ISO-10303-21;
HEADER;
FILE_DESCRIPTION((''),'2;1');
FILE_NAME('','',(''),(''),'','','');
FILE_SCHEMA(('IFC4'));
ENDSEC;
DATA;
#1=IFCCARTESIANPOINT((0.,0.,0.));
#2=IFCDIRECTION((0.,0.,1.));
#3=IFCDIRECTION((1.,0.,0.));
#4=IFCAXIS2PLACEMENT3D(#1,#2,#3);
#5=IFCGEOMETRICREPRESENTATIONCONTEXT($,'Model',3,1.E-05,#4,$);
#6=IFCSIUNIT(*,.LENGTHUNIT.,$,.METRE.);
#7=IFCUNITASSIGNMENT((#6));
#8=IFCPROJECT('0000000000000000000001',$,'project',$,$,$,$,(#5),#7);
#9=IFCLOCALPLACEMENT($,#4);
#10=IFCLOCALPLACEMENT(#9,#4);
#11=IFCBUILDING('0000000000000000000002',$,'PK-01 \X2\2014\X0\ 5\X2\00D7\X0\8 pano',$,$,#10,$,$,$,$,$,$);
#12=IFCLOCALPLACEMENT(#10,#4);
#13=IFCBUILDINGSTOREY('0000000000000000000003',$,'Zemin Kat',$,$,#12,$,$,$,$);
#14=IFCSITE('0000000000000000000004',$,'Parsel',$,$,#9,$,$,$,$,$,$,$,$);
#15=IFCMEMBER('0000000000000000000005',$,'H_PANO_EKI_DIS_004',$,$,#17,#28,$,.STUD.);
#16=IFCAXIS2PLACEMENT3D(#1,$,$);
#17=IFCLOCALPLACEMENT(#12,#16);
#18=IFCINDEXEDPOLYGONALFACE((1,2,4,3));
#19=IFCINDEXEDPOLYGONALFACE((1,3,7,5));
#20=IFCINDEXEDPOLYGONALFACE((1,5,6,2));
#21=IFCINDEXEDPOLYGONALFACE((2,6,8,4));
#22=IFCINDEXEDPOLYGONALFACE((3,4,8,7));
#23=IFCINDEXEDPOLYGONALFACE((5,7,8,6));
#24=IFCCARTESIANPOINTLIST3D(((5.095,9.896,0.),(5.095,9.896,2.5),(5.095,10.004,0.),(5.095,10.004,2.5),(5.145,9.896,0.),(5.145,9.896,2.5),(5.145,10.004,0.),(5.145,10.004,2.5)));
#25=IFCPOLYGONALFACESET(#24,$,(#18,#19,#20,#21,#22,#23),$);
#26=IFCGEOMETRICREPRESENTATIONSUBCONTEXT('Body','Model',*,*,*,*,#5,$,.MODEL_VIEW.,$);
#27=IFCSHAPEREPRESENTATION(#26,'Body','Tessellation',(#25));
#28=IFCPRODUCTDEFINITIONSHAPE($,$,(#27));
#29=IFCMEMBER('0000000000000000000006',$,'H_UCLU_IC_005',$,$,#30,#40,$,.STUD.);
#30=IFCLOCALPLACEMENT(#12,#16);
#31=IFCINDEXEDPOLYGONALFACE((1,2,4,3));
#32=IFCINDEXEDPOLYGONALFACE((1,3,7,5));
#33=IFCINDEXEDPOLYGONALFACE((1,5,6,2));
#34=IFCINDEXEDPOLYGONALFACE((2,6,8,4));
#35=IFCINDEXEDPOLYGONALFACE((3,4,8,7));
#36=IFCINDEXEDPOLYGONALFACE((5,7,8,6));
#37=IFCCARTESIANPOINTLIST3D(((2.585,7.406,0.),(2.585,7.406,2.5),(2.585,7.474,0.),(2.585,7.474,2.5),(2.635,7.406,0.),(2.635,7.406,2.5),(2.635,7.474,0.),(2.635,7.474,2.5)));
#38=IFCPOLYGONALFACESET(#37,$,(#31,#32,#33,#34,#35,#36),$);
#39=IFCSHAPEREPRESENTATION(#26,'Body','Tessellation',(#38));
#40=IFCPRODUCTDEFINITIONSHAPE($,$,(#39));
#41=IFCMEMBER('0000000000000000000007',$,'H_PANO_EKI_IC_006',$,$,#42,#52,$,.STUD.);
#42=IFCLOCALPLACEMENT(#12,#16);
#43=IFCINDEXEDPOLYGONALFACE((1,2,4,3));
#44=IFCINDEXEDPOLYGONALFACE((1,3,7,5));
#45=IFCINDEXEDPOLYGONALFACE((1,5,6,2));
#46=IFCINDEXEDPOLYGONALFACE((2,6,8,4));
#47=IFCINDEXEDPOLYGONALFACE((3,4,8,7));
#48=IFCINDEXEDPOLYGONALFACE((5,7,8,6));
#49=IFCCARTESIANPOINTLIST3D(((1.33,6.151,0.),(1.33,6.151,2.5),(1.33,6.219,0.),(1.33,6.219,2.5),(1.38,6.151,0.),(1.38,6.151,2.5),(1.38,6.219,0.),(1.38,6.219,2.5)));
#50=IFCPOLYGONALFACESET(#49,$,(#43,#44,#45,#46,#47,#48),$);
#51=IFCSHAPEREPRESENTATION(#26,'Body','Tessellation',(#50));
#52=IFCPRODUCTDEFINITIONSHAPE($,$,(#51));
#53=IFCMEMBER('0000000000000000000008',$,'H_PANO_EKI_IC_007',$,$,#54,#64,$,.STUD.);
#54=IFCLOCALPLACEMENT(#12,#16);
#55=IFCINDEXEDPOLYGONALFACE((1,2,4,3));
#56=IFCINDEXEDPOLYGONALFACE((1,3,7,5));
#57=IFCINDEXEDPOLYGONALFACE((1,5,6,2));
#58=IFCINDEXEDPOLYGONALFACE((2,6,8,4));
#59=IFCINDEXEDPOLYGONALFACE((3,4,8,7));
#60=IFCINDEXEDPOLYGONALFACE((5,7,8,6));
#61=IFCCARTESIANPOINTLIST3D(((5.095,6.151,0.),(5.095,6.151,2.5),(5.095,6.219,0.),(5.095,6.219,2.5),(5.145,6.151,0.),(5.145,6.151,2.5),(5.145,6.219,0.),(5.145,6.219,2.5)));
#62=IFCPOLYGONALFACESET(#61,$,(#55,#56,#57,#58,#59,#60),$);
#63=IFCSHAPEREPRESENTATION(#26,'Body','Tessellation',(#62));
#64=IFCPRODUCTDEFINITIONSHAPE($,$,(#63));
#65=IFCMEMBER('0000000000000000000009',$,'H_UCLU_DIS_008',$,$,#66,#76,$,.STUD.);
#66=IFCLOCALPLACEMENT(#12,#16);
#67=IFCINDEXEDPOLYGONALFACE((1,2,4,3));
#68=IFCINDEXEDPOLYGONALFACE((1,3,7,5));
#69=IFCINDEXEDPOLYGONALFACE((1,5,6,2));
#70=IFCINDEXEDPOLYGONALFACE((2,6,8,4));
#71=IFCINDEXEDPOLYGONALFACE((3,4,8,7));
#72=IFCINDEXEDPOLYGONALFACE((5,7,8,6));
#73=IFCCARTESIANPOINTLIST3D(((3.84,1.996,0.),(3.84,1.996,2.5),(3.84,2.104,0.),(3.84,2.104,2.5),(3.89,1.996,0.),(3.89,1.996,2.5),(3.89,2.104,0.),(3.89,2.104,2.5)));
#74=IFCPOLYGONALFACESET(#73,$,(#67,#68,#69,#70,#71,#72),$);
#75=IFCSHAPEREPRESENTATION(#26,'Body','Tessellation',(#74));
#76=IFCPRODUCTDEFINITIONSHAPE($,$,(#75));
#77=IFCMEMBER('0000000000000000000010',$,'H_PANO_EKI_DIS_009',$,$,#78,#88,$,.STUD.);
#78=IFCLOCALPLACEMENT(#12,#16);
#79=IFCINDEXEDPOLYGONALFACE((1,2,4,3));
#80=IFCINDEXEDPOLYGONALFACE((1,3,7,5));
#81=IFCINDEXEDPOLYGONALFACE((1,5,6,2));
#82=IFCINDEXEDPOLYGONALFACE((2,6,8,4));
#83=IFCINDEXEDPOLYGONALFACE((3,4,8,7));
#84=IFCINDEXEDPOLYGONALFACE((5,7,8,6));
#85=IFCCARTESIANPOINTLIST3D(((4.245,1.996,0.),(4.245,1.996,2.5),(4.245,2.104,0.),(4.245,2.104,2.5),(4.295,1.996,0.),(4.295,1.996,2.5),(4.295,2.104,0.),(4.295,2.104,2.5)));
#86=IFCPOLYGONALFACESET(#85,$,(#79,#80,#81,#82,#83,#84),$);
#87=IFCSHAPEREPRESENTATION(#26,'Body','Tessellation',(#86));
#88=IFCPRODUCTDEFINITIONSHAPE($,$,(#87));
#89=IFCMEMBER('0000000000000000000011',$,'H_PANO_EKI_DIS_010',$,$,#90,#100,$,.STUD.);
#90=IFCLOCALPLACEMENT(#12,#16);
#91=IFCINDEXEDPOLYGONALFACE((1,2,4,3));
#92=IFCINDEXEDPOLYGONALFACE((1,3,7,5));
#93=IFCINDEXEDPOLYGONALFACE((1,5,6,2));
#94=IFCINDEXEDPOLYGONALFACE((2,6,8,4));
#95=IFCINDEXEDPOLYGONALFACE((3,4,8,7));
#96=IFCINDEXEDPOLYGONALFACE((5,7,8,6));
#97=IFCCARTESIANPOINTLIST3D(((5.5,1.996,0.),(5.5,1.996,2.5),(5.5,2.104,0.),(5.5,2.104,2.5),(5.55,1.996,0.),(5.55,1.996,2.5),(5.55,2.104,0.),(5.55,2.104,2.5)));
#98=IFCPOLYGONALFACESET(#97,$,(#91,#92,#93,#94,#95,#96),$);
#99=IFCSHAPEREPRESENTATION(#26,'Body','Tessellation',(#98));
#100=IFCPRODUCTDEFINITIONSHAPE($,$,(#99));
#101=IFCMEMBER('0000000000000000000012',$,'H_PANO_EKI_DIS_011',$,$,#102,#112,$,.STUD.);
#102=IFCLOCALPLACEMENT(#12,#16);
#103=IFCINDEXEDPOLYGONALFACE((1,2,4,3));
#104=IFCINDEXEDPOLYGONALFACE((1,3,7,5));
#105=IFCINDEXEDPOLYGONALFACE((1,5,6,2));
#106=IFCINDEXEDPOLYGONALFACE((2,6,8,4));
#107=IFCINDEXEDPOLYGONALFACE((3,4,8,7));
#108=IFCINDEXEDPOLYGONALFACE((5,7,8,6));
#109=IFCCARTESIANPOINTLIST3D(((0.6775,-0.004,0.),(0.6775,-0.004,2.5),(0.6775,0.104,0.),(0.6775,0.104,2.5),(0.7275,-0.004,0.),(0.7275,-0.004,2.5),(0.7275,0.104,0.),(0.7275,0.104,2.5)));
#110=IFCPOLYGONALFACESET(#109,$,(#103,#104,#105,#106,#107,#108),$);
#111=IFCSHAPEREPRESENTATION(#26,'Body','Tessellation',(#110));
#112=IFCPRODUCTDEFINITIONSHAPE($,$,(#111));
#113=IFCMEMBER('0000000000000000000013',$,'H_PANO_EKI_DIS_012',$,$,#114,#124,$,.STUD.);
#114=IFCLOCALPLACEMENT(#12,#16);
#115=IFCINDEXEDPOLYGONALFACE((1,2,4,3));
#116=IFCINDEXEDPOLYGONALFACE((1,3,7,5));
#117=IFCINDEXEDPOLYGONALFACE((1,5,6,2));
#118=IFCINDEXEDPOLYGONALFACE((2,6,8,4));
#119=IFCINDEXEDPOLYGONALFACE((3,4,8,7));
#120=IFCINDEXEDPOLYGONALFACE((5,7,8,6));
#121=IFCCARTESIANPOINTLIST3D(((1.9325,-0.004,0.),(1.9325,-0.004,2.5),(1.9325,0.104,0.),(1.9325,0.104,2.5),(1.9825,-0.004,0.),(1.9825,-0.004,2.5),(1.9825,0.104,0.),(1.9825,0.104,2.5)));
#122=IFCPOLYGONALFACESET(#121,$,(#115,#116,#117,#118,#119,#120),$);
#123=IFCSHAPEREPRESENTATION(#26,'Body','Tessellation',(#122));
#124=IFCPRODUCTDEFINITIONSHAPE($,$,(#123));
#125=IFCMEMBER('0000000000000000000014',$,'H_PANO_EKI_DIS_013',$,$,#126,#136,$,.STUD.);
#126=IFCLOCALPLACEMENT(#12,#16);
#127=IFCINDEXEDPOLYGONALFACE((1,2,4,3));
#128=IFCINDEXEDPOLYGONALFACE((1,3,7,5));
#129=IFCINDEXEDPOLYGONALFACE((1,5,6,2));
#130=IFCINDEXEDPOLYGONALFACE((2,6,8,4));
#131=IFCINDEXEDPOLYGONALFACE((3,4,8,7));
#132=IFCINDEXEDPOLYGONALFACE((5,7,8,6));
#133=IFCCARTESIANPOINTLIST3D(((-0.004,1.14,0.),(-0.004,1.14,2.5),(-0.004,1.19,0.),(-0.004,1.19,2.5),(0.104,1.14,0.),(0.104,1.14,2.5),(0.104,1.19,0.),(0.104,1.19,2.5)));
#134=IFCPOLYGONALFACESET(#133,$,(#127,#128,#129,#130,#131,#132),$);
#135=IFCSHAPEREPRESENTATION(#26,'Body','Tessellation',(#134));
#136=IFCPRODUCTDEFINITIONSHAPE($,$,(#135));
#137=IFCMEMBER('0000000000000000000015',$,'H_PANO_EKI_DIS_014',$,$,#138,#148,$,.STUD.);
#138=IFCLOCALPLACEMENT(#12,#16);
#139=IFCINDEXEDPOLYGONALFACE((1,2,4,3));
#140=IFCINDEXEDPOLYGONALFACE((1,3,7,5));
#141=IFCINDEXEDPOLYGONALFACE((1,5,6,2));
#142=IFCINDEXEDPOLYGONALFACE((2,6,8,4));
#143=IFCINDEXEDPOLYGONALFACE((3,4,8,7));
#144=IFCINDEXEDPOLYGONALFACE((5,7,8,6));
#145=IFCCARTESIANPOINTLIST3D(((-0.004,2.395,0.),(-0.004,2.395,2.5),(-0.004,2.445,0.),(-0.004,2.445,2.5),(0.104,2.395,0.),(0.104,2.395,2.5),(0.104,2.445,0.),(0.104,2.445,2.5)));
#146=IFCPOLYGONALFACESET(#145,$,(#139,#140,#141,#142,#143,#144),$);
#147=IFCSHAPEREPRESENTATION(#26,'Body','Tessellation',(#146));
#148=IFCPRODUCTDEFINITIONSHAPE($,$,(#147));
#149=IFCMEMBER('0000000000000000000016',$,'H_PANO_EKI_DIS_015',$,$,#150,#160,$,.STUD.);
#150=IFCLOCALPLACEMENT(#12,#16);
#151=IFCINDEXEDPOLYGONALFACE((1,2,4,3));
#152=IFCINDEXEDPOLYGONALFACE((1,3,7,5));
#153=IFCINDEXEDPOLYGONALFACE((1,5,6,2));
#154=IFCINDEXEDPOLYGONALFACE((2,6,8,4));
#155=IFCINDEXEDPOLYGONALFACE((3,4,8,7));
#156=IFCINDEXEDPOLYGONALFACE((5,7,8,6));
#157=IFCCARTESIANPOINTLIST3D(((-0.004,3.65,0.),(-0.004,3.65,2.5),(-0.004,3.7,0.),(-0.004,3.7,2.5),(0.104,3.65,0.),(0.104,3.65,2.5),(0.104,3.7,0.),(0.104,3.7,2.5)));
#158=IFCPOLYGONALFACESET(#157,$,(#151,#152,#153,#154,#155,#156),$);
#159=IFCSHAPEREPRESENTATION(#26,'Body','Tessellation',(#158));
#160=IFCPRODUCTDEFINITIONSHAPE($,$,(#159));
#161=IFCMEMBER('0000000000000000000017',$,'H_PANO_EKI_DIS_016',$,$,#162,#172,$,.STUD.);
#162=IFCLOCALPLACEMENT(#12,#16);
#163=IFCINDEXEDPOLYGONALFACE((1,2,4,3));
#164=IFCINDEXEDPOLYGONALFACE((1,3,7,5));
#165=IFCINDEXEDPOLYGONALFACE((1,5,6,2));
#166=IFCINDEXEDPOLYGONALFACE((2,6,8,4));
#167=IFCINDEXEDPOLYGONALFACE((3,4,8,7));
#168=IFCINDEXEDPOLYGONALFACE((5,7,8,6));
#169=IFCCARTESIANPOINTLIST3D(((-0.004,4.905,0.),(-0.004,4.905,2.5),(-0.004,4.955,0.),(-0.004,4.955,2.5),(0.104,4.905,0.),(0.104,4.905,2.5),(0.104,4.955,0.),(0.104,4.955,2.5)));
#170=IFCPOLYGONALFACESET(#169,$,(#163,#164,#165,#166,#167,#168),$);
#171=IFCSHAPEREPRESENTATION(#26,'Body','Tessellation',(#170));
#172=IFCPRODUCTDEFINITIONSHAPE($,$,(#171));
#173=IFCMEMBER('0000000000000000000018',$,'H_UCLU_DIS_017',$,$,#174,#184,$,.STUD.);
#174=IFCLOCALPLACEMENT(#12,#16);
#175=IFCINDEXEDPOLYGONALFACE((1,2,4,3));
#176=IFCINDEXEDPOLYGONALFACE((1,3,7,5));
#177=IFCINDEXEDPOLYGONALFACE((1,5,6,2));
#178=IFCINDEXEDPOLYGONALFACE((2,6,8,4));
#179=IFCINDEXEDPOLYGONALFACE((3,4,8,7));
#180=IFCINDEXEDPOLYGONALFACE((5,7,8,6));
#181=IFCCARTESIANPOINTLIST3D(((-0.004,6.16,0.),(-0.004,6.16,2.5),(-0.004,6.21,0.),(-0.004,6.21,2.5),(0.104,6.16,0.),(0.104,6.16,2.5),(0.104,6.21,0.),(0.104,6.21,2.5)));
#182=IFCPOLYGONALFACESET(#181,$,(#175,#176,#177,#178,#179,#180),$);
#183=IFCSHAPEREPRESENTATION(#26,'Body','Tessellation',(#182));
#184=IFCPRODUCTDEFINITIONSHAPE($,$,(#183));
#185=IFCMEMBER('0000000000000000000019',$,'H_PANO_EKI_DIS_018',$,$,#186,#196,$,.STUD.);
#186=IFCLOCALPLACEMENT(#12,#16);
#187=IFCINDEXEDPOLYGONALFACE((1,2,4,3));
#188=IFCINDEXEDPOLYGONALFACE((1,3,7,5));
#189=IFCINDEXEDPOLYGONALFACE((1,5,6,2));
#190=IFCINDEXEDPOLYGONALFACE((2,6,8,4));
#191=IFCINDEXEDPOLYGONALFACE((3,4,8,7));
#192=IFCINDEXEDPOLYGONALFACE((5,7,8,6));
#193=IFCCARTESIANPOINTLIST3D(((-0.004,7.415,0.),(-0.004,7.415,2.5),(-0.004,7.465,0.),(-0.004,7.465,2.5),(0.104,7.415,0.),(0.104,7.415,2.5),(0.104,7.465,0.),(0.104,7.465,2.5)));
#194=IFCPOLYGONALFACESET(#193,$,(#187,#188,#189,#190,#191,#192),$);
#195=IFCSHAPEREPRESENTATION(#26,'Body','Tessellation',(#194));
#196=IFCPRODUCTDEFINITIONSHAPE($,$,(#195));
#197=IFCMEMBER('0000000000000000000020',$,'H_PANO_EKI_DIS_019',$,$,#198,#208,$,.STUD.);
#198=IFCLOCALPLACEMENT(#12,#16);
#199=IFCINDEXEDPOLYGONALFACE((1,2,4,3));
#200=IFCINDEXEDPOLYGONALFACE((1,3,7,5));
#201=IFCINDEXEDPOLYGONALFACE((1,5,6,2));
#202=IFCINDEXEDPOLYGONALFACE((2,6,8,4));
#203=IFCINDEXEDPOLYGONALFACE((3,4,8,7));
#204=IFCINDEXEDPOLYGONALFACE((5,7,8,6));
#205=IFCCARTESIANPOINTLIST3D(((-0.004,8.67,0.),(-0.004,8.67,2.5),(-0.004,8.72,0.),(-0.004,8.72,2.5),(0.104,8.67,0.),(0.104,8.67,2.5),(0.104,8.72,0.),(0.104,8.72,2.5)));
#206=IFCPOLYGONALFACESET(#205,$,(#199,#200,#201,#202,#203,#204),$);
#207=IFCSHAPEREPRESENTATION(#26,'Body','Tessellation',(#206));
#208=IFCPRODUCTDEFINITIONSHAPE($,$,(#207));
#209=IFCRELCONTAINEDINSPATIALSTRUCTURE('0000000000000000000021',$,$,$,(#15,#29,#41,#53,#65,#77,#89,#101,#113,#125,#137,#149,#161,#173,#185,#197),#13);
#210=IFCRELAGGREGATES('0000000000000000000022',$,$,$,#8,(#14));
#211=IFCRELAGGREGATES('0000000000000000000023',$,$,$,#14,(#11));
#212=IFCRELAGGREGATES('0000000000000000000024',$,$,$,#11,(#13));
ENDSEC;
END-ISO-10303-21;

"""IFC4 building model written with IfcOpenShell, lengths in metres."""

from ifc_helpers import new_model, si_unit, origin_with_axes, place, context, subcontext, project, spatial, line, indexed_curve, outline, extrude, element, save


model = new_model("IFC4")

# Units and contexts
model_context = context("Model", 3, precision=1e-05, world=origin_with_axes())
body_context = subcontext(model_context, "Body", "Model", "MODEL_VIEW")
ifc_project = project(units=[si_unit("LENGTHUNIT", "METRE")], contexts=[model_context])

# Site, building, storey
site_placement = place(None, origin_with_axes())
site = spatial("IfcSite", under=ifc_project, at=site_placement, Name="Parsel")
building_placement = place(site_placement, origin_with_axes())
building = spatial("IfcBuilding", under=site, at=building_placement, Name="PK-01 — 5×8 pano")
storey_placement = place(building_placement, origin_with_axes())
storey = spatial("IfcBuildingStorey", under=building, at=storey_placement, Name="Zemin Kat")

# Members
member_1_placement = place(storey_placement, origin_with_axes())
element("IfcMember", 1, at=member_1_placement, inside=storey, Name="H_PANO_EKI_DIS_004", PredefinedType="STUD", context=body_context, shape_type="SweptSolid", body=[
    extrude(outline(indexed_curve([(5.095, 9.896), (5.145, 9.896), (5.145, 10.004), (5.095, 10.004)], segments=[line(1, 2, 3, 4, 1)])), origin_with_axes(), (0.0, 0.0, 1.0), 2.5),
])
member_2_placement = place(storey_placement, origin_with_axes())
element("IfcMember", 2, at=member_2_placement, inside=storey, Name="H_UCLU_IC_005", PredefinedType="STUD", context=body_context, shape_type="SweptSolid", body=[
    extrude(outline(indexed_curve([(2.585, 7.406), (2.635, 7.406), (2.635, 7.474), (2.585, 7.474)], segments=[line(1, 2, 3, 4, 1)])), origin_with_axes(), (0.0, 0.0, 1.0), 2.5),
])
member_3_placement = place(storey_placement, origin_with_axes())
element("IfcMember", 3, at=member_3_placement, inside=storey, Name="H_PANO_EKI_IC_006", PredefinedType="STUD", context=body_context, shape_type="SweptSolid", body=[
    extrude(outline(indexed_curve([(1.33, 6.151), (1.38, 6.151), (1.38, 6.219), (1.33, 6.219)], segments=[line(1, 2, 3, 4, 1)])), origin_with_axes(), (0.0, 0.0, 1.0), 2.5),
])
member_4_placement = place(storey_placement, origin_with_axes())
element("IfcMember", 4, at=member_4_placement, inside=storey, Name="H_PANO_EKI_IC_007", PredefinedType="STUD", context=body_context, shape_type="SweptSolid", body=[
    extrude(outline(indexed_curve([(5.095, 6.151), (5.145, 6.151), (5.145, 6.219), (5.095, 6.219)], segments=[line(1, 2, 3, 4, 1)])), origin_with_axes(), (0.0, 0.0, 1.0), 2.5),
])
member_5_placement = place(storey_placement, origin_with_axes())
element("IfcMember", 5, at=member_5_placement, inside=storey, Name="H_UCLU_DIS_008", PredefinedType="STUD", context=body_context, shape_type="SweptSolid", body=[
    extrude(outline(indexed_curve([(3.84, 1.996), (3.89, 1.996), (3.89, 2.104), (3.84, 2.104)], segments=[line(1, 2, 3, 4, 1)])), origin_with_axes(), (0.0, 0.0, 1.0), 2.5),
])
member_6_placement = place(storey_placement, origin_with_axes())
element("IfcMember", 6, at=member_6_placement, inside=storey, Name="H_PANO_EKI_DIS_009", PredefinedType="STUD", context=body_context, shape_type="SweptSolid", body=[
    extrude(outline(indexed_curve([(4.245, 1.996), (4.295, 1.996), (4.295, 2.104), (4.245, 2.104)], segments=[line(1, 2, 3, 4, 1)])), origin_with_axes(), (0.0, 0.0, 1.0), 2.5),
])
member_7_placement = place(storey_placement, origin_with_axes())
element("IfcMember", 7, at=member_7_placement, inside=storey, Name="H_PANO_EKI_DIS_010", PredefinedType="STUD", context=body_context, shape_type="SweptSolid", body=[
    extrude(outline(indexed_curve([(5.5, 1.996), (5.55, 1.996), (5.55, 2.104), (5.5, 2.104)], segments=[line(1, 2, 3, 4, 1)])), origin_with_axes(), (0.0, 0.0, 1.0), 2.5),
])
member_8_placement = place(storey_placement, origin_with_axes())
element("IfcMember", 8, at=member_8_placement, inside=storey, Name="H_PANO_EKI_DIS_011", PredefinedType="STUD", context=body_context, shape_type="SweptSolid", body=[
    extrude(outline(indexed_curve([(0.6775, -0.004), (0.7275, -0.004), (0.7275, 0.104), (0.6775, 0.104)], segments=[line(1, 2, 3, 4, 1)])), origin_with_axes(), (0.0, 0.0, 1.0), 2.5),
])
member_9_placement = place(storey_placement, origin_with_axes())
element("IfcMember", 9, at=member_9_placement, inside=storey, Name="H_PANO_EKI_DIS_012", PredefinedType="STUD", context=body_context, shape_type="SweptSolid", body=[
    extrude(outline(indexed_curve([(1.9325, -0.004), (1.9825, -0.004), (1.9825, 0.104), (1.9325, 0.104)], segments=[line(1, 2, 3, 4, 1)])), origin_with_axes(), (0.0, 0.0, 1.0), 2.5),
])
member_10_placement = place(storey_placement, origin_with_axes())
element("IfcMember", 10, at=member_10_placement, inside=storey, Name="H_PANO_EKI_DIS_013", PredefinedType="STUD", context=body_context, shape_type="SweptSolid", body=[
    extrude(outline(indexed_curve([(-0.004, 1.14), (0.104, 1.14), (0.104, 1.19), (-0.004, 1.19)], segments=[line(1, 2, 3, 4, 1)])), origin_with_axes(), (0.0, 0.0, 1.0), 2.5),
])
member_11_placement = place(storey_placement, origin_with_axes())
element("IfcMember", 11, at=member_11_placement, inside=storey, Name="H_PANO_EKI_DIS_014", PredefinedType="STUD", context=body_context, shape_type="SweptSolid", body=[
    extrude(outline(indexed_curve([(-0.004, 2.395), (0.104, 2.395), (0.104, 2.445), (-0.004, 2.445)], segments=[line(1, 2, 3, 4, 1)])), origin_with_axes(), (0.0, 0.0, 1.0), 2.5),
])
member_12_placement = place(storey_placement, origin_with_axes())
element("IfcMember", 12, at=member_12_placement, inside=storey, Name="H_PANO_EKI_DIS_015", PredefinedType="STUD", context=body_context, shape_type="SweptSolid", body=[
    extrude(outline(indexed_curve([(-0.004, 3.65), (0.104, 3.65), (0.104, 3.7), (-0.004, 3.7)], segments=[line(1, 2, 3, 4, 1)])), origin_with_axes(), (0.0, 0.0, 1.0), 2.5),
])
member_13_placement = place(storey_placement, origin_with_axes())
element("IfcMember", 13, at=member_13_placement, inside=storey, Name="H_PANO_EKI_DIS_016", PredefinedType="STUD", context=body_context, shape_type="SweptSolid", body=[
    extrude(outline(indexed_curve([(-0.004, 4.905), (0.104, 4.905), (0.104, 4.955), (-0.004, 4.955)], segments=[line(1, 2, 3, 4, 1)])), origin_with_axes(), (0.0, 0.0, 1.0), 2.5),
])
member_14_placement = place(storey_placement, origin_with_axes())
element("IfcMember", 14, at=member_14_placement, inside=storey, Name="H_UCLU_DIS_017", PredefinedType="STUD", context=body_context, shape_type="SweptSolid", body=[
    extrude(outline(indexed_curve([(-0.004, 6.16), (0.104, 6.16), (0.104, 6.21), (-0.004, 6.21)], segments=[line(1, 2, 3, 4, 1)])), origin_with_axes(), (0.0, 0.0, 1.0), 2.5),
])
member_15_placement = place(storey_placement, origin_with_axes())
element("IfcMember", 15, at=member_15_placement, inside=storey, Name="H_PANO_EKI_DIS_018", PredefinedType="STUD", context=body_context, shape_type="SweptSolid", body=[
    extrude(outline(indexed_curve([(-0.004, 7.415), (0.104, 7.415), (0.104, 7.465), (-0.004, 7.465)], segments=[line(1, 2, 3, 4, 1)])), origin_with_axes(), (0.0, 0.0, 1.0), 2.5),
])
member_16_placement = place(storey_placement, origin_with_axes())
element("IfcMember", 16, at=member_16_placement, inside=storey, Name="H_PANO_EKI_DIS_019", PredefinedType="STUD", context=body_context, shape_type="SweptSolid", body=[
    extrude(outline(indexed_curve([(-0.004, 8.67), (0.104, 8.67), (0.104, 8.72), (-0.004, 8.72)], segments=[line(1, 2, 3, 4, 1)])), origin_with_axes(), (0.0, 0.0, 1.0), 2.5),
])

save(model, "model.ifc")
